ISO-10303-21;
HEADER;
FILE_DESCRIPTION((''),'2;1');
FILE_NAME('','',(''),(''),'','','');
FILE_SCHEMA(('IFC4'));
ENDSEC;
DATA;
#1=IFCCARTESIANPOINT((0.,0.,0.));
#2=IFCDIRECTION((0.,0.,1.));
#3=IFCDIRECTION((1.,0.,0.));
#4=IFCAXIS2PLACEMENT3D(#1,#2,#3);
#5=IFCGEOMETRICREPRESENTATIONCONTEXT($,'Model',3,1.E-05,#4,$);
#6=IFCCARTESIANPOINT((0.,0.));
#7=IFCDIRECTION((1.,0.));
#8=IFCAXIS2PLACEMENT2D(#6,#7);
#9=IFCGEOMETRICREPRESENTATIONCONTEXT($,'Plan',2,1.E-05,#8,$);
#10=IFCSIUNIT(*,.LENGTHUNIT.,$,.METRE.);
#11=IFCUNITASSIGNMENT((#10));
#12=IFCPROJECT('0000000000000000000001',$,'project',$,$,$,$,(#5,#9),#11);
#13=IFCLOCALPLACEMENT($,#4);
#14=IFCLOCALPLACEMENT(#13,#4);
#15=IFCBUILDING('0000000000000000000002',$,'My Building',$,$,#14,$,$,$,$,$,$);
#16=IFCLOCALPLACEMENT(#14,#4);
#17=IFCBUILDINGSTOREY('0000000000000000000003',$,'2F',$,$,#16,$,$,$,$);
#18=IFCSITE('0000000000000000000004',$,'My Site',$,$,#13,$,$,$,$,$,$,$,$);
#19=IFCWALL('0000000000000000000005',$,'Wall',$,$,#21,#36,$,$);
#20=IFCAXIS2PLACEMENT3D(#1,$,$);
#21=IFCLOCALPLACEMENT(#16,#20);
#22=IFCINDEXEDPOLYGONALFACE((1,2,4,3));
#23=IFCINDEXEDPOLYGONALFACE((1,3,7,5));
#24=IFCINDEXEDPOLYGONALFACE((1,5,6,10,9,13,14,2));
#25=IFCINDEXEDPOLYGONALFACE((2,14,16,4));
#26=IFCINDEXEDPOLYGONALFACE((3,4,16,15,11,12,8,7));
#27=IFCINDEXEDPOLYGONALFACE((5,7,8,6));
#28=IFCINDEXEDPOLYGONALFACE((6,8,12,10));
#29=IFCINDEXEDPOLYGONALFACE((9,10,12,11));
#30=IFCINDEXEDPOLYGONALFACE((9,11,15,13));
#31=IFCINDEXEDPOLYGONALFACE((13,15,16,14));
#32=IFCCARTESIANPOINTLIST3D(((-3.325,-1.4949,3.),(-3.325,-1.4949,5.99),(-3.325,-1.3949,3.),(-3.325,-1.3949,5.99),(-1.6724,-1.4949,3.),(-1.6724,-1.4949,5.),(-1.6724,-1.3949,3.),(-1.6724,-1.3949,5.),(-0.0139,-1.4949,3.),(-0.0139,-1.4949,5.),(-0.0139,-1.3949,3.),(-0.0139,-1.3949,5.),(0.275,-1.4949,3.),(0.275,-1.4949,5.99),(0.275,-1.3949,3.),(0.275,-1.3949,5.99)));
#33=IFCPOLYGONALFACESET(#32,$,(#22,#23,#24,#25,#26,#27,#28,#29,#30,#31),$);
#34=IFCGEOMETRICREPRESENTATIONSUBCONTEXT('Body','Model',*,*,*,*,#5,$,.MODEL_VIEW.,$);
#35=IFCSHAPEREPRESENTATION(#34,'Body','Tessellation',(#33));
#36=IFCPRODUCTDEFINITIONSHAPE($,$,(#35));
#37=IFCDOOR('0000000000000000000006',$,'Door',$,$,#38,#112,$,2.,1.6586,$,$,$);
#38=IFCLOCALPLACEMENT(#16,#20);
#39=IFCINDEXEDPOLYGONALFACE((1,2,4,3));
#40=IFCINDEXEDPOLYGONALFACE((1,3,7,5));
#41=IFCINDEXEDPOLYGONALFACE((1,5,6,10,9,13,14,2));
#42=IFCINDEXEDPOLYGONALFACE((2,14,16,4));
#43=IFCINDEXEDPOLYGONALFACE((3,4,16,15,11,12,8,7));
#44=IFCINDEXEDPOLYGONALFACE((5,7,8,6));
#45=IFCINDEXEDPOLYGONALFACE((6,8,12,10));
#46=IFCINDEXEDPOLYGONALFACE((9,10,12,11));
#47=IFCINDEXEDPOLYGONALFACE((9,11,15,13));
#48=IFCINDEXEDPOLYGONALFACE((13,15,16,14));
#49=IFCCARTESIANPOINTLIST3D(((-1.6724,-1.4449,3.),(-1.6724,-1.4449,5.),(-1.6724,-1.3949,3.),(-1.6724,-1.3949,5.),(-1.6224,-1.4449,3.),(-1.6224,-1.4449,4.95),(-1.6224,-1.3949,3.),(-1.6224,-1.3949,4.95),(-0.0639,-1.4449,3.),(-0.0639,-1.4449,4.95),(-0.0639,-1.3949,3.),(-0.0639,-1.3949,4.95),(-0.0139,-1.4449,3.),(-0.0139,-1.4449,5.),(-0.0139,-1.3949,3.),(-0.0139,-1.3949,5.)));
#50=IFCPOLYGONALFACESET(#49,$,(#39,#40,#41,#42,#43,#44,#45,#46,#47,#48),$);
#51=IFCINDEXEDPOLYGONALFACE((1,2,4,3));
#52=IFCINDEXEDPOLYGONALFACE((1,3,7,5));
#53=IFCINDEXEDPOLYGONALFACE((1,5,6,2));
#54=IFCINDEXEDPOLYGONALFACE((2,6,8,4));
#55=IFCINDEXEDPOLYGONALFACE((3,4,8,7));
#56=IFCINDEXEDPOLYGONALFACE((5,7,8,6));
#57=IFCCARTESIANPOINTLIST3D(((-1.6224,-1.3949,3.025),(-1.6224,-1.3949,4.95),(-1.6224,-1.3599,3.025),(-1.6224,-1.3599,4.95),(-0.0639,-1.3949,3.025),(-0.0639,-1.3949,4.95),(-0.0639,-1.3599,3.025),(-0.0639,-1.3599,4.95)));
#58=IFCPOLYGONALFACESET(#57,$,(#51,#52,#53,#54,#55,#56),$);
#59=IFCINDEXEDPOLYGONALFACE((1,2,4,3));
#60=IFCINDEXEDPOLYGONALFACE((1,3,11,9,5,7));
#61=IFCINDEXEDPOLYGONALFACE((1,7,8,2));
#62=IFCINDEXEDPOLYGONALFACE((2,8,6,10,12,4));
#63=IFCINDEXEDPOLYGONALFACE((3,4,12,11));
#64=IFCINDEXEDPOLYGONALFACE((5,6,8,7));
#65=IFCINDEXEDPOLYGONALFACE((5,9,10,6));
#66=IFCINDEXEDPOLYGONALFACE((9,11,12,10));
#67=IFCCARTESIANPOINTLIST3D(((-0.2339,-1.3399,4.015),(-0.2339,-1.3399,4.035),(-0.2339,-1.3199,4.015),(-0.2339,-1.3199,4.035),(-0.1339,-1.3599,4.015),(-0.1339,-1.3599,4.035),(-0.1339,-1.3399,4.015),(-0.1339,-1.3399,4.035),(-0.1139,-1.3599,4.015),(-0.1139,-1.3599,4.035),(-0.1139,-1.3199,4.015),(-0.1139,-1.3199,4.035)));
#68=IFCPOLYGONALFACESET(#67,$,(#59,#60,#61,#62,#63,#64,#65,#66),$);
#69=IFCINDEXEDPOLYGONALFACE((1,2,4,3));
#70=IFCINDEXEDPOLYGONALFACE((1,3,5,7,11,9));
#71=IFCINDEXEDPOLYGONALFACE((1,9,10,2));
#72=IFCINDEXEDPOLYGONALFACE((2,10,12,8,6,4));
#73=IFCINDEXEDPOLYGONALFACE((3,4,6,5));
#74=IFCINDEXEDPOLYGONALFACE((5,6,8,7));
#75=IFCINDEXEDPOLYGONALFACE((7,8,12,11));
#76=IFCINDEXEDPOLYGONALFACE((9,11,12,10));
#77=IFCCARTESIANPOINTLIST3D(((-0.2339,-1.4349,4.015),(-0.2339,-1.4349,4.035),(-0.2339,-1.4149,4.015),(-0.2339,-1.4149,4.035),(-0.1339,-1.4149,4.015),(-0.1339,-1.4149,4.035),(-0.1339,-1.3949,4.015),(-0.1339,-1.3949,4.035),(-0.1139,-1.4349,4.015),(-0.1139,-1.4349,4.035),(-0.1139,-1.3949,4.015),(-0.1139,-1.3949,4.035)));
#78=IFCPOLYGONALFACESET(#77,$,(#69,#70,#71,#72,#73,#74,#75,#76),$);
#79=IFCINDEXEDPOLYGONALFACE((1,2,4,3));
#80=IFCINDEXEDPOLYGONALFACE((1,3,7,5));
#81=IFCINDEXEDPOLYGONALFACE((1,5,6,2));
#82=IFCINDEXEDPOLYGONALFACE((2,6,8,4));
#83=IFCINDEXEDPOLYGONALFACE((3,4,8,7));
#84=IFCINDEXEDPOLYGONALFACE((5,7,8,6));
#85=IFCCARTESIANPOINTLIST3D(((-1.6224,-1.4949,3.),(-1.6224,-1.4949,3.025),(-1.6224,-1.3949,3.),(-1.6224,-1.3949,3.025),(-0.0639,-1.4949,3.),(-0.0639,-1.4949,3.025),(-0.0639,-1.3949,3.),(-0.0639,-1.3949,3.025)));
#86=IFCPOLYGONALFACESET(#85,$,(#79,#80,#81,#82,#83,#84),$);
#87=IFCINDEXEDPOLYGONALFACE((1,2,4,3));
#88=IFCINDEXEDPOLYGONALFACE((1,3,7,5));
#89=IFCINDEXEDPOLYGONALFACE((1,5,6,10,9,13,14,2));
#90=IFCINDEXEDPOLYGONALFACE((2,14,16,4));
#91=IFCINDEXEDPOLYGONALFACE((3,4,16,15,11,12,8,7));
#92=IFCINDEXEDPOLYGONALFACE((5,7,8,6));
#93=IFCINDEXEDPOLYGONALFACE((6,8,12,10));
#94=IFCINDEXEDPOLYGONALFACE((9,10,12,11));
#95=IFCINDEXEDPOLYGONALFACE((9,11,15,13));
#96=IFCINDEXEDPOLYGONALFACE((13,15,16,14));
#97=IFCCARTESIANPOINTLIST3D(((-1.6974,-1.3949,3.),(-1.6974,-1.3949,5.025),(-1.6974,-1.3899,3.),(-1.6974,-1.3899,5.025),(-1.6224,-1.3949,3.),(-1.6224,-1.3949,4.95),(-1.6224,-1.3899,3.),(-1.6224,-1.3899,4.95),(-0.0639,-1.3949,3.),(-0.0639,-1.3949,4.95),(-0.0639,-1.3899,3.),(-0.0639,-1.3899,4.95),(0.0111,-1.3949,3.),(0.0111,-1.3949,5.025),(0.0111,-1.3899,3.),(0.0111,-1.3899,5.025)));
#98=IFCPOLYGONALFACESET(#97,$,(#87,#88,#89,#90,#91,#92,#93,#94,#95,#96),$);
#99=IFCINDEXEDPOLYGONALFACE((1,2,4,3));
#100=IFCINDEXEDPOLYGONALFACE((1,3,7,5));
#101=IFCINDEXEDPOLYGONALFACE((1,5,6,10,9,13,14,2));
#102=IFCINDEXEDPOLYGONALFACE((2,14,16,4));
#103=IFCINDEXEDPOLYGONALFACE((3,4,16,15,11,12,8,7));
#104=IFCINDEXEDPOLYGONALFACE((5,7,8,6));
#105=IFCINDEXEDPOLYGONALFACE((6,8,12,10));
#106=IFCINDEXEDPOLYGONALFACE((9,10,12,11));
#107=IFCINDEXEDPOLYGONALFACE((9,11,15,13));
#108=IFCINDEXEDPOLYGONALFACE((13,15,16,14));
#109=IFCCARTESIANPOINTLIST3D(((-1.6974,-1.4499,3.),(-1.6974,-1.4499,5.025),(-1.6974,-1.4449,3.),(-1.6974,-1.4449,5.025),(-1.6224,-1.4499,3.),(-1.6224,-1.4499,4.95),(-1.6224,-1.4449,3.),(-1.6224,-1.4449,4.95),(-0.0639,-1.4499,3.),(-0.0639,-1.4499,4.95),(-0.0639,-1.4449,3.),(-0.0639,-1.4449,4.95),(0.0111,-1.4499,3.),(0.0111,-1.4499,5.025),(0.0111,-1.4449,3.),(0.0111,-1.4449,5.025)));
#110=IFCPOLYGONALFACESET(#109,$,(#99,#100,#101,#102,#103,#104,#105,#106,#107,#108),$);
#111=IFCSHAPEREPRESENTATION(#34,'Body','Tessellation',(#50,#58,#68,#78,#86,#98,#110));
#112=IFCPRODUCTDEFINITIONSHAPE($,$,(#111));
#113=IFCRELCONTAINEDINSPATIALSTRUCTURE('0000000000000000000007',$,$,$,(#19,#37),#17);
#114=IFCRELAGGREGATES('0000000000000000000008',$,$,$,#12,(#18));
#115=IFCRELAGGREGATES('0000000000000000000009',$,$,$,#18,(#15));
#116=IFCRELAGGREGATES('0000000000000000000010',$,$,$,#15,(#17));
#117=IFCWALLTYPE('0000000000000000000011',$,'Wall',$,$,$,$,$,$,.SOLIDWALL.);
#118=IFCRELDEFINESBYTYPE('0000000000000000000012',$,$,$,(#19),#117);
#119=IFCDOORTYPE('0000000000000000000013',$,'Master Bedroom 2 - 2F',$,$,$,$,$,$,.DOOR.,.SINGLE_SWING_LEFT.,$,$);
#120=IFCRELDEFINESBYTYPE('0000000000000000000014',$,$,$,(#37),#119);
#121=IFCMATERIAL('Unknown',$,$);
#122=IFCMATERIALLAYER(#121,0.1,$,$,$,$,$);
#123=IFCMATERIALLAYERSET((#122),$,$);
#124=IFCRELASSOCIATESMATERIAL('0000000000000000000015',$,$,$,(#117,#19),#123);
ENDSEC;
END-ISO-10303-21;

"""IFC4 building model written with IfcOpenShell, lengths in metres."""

from ifc_helpers import new_model, entity, si_unit, frame, origin_with_axes, origin_2d_with_axis, place, context, subcontext, project, spatial, line, indexed_curve, outline, extrude, shape, source, transform, mapped, material, layer, layer_set, layer_usage, type_object, type_shapes, element, fill, save


model = new_model("IFC4")

# Units and contexts
model_context = context("Model", 3, precision=1e-05, world=origin_with_axes())
plan_context = context("Plan", 2, precision=1e-05, world=origin_2d_with_axis())
body_context_1 = subcontext(model_context, "Body", "Model", "MODEL_VIEW")
body_context_2 = subcontext(plan_context, "Body", "Plan", "PLAN_VIEW")
ifc_project = project(units=[si_unit("LENGTHUNIT", "METRE")], contexts=[model_context, plan_context])

# Site, building, storey
site_placement = place(None, origin_with_axes())
site = spatial("IfcSite", under=ifc_project, at=site_placement, Name="My Site")
building_placement = place(site_placement, origin_with_axes())
building = spatial("IfcBuilding", under=site, at=building_placement, Name="My Building")
storey_placement = place(building_placement, origin_with_axes())
storey = spatial("IfcBuildingStorey", under=building, at=storey_placement, Name="2F")

# Shared definitions
ifc_material = material(Name="Unknown")

# Shared definitions
ifc_layer_1 = layer(ifc_material, 0.1)
ifc_layer_set_1 = layer_set([ifc_layer_1])
wall_type = type_object("IfcWallType", Name="Wall", PredefinedType="SOLIDWALL", material=ifc_layer_set_1)

# Wall, opening, door
ifc_layer_usage_1 = layer_usage(ifc_layer_set_1, "AXIS2", "POSITIVE", 0.0)
wall_1_placement = place(storey_placement, frame((-3.325, -1.4949, 3.0), z_axis=(0.0, 0.0, 1.0), x_axis=(1.0, 0.0, 0.0)))
wall_1 = element("IfcWall", 1, at=wall_1_placement, inside=storey, type_object=wall_type, material=ifc_layer_usage_1, Name="Wall", context=body_context_1, shape_type="SweptSolid", body=[
    extrude(outline(indexed_curve([(0.0, 0.0), (0.0, 0.1), (3.6, 0.1), (3.6, 0.0)], segments=[line(1, 2, 3, 4, 1)])), origin_with_axes(), (0.0, 0.0, 1.0), 2.99),
])
shared_shape_1 = source(origin_with_axes(), body_context_1, "Body", "SweptSolid", [
    extrude(outline(indexed_curve([(0.0, 0.0), (1.6586, 0.0), (1.6586, 2.0), (0.0, 2.0)], segments=[line(1, 2, 3, 4, 1)])), frame((0.0, -0.6, 0.0), z_axis=(0.0, -1.0, 0.0), x_axis=(1.0, 0.0, 0.0)), (0.0, 0.0, -1.0), 1.2),
])
opening_1_placement = place(wall_1_placement, frame((3.3111, 0.1, 0.0), z_axis=(0.0, 0.0, 1.0), x_axis=(-1.0, 0.0, 0.0)))
opening_1 = element("IfcOpeningElement", 2, at=opening_1_placement, cuts=wall_1, PredefinedType="OPENING", context=body_context_1, shape_type="MappedRepresentation", body=[
    mapped(shared_shape_1, transform((0.0, 0.0, 0.0), x_axis=(1.0, 0.0, 0.0), y_axis=(0.0, 1.0, 0.0), z_axis=(0.0, 0.0, 1.0), scale=1.0)),
])
door_type_1 = type_object("IfcDoorType", Name="Master Bedroom 2 - 2F", OperationType="SINGLE_SWING_LEFT", PredefinedType="DOOR")
shared_shape_2 = source(origin_with_axes(), body_context_1, "Body", "SweptSolid", [
    extrude(outline(indexed_curve([(0.0, 0.0), (0.0, 2.0), (1.6586, 2.0), (1.6586, 0.0), (1.6086, 0.0), (1.6086, 1.95), (0.05, 1.95), (0.05, 0.0)], segments=[line(1, 2, 3, 4, 5, 6, 7, 8, 1)])), frame((0.0, 0.0, 0.0), z_axis=(0.0, -1.0, 0.0), x_axis=(1.0, 0.0, 0.0)), (0.0, 0.0, -1.0), 0.05),
    extrude(outline(indexed_curve([(0.0, 0.0), (1.5586, 0.0), (1.5586, 0.035), (0.0, 0.035)], segments=[line(1, 2, 3, 4, 1)])), frame((0.05, -0.035, 0.025), z_axis=(0.0, 0.0, 1.0), x_axis=(1.0, 0.0, 0.0)), (0.0, 0.0, 1.0), 1.925),
    extrude(outline(indexed_curve([(0.0, 0.0), (0.0, -0.04), (0.12, -0.04), (0.12, -0.02), (0.02, -0.02), (0.02, 0.0)], segments=[line(1, 2, 3, 4, 5, 6, 1)])), frame((0.1, -0.035, 1.015), z_axis=(0.0, 0.0, 1.0), x_axis=(1.0, 0.0, 0.0)), (0.0, 0.0, 1.0), 0.02),
    extrude(outline(indexed_curve([(0.0, 0.0), (0.0, 0.04), (0.12, 0.04), (0.12, 0.02), (0.02, 0.02), (0.02, 0.0)], segments=[line(1, 2, 3, 4, 5, 6, 1)])), frame((0.1, 0.0, 1.015), z_axis=(0.0, 0.0, 1.0), x_axis=(1.0, 0.0, 0.0)), (0.0, 0.0, 1.0), 0.02),
    extrude(outline(indexed_curve([(0.0, 0.0), (1.5586, 0.0), (1.5586, 0.1), (0.0, 0.1)], segments=[line(1, 2, 3, 4, 1)])), frame((0.05, 0.0, 0.0), z_axis=(0.0, 0.0, 1.0), x_axis=(1.0, 0.0, 0.0)), (0.0, 0.0, 1.0), 0.025),
    extrude(outline(indexed_curve([(0.0, 0.0), (0.0, 2.025), (1.7086, 2.025), (1.7086, 0.0), (1.6336, 0.0), (1.6336, 1.95), (0.075, 1.95), (0.075, 0.0)], segments=[line(1, 2, 3, 4, 5, 6, 7, 8, 1)])), frame((-0.025, -0.005, 0.0), z_axis=(0.0, -1.0, 0.0), x_axis=(1.0, 0.0, 0.0)), (0.0, 0.0, -1.0), 0.005),
    extrude(outline(indexed_curve([(0.0, 0.0), (0.0, 2.025), (1.7086, 2.025), (1.7086, 0.0), (1.6336, 0.0), (1.6336, 1.95), (0.075, 1.95), (0.075, 0.0)], segments=[line(1, 2, 3, 4, 5, 6, 7, 8, 1)])), frame((-0.025, 0.05, 0.0), z_axis=(0.0, -1.0, 0.0), x_axis=(1.0, 0.0, 0.0)), (0.0, 0.0, -1.0), 0.005),
])
shared_shape_3 = source(origin_with_axes(), body_context_2, "Body", "Curve2D", [
    entity("IfcIndexedPolyCurve", entity("IfcCartesianPointList2D", [[0.0, 0.0], [0.05, 0.0], [0.05, 0.05], [0.0, 0.05]]), [entity("IfcLineIndex", [1, 2, 3, 4, 1])]),
    entity("IfcIndexedPolyCurve", entity("IfcCartesianPointList2D", [[1.6586, 0.0], [1.6086, 0.0], [1.6086, 0.05], [1.6586, 0.05]]), [entity("IfcLineIndex", [1, 2, 3, 4, 1])]),
    entity("IfcIndexedPolyCurve", entity("IfcCartesianPointList2D", [[2.3879, -0.035], [0.8293, -0.035], [0.8293, 0.0], [2.3879, 0.0]]), [entity("IfcLineIndex", [1, 2, 3, 4, 1])]),
])
type_shapes(door_type_1, [shared_shape_2, shared_shape_3])
door_1_placement = place(opening_1_placement, frame((0.0, 0.0, 0.0), z_axis=(0.0, 0.0, 1.0), x_axis=(1.0, 0.0, 0.0)))
door_1 = element("IfcDoor", 3, at=door_1_placement, inside=storey, type_object=door_type_1, Name="Door", OverallHeight=2.0, OverallWidth=1.6586, shapes=[
    shape(body_context_1, "Body", "MappedRepresentation", [mapped(shared_shape_2, transform((0.0, 0.0, 0.0), x_axis=(1.0, 0.0, 0.0), y_axis=(0.0, 1.0, 0.0), z_axis=(0.0, 0.0, 1.0), scale=1.0))]),
    shape(body_context_2, "Body", "MappedRepresentation", [mapped(shared_shape_3, transform((0.0, 0.0, 0.0), x_axis=(1.0, 0.0, 0.0), y_axis=(0.0, 1.0, 0.0), z_axis=(0.0, 0.0, 1.0), scale=1.0))]),
])
fill(opening_1, door_1)

save(model, "model.ifc")
